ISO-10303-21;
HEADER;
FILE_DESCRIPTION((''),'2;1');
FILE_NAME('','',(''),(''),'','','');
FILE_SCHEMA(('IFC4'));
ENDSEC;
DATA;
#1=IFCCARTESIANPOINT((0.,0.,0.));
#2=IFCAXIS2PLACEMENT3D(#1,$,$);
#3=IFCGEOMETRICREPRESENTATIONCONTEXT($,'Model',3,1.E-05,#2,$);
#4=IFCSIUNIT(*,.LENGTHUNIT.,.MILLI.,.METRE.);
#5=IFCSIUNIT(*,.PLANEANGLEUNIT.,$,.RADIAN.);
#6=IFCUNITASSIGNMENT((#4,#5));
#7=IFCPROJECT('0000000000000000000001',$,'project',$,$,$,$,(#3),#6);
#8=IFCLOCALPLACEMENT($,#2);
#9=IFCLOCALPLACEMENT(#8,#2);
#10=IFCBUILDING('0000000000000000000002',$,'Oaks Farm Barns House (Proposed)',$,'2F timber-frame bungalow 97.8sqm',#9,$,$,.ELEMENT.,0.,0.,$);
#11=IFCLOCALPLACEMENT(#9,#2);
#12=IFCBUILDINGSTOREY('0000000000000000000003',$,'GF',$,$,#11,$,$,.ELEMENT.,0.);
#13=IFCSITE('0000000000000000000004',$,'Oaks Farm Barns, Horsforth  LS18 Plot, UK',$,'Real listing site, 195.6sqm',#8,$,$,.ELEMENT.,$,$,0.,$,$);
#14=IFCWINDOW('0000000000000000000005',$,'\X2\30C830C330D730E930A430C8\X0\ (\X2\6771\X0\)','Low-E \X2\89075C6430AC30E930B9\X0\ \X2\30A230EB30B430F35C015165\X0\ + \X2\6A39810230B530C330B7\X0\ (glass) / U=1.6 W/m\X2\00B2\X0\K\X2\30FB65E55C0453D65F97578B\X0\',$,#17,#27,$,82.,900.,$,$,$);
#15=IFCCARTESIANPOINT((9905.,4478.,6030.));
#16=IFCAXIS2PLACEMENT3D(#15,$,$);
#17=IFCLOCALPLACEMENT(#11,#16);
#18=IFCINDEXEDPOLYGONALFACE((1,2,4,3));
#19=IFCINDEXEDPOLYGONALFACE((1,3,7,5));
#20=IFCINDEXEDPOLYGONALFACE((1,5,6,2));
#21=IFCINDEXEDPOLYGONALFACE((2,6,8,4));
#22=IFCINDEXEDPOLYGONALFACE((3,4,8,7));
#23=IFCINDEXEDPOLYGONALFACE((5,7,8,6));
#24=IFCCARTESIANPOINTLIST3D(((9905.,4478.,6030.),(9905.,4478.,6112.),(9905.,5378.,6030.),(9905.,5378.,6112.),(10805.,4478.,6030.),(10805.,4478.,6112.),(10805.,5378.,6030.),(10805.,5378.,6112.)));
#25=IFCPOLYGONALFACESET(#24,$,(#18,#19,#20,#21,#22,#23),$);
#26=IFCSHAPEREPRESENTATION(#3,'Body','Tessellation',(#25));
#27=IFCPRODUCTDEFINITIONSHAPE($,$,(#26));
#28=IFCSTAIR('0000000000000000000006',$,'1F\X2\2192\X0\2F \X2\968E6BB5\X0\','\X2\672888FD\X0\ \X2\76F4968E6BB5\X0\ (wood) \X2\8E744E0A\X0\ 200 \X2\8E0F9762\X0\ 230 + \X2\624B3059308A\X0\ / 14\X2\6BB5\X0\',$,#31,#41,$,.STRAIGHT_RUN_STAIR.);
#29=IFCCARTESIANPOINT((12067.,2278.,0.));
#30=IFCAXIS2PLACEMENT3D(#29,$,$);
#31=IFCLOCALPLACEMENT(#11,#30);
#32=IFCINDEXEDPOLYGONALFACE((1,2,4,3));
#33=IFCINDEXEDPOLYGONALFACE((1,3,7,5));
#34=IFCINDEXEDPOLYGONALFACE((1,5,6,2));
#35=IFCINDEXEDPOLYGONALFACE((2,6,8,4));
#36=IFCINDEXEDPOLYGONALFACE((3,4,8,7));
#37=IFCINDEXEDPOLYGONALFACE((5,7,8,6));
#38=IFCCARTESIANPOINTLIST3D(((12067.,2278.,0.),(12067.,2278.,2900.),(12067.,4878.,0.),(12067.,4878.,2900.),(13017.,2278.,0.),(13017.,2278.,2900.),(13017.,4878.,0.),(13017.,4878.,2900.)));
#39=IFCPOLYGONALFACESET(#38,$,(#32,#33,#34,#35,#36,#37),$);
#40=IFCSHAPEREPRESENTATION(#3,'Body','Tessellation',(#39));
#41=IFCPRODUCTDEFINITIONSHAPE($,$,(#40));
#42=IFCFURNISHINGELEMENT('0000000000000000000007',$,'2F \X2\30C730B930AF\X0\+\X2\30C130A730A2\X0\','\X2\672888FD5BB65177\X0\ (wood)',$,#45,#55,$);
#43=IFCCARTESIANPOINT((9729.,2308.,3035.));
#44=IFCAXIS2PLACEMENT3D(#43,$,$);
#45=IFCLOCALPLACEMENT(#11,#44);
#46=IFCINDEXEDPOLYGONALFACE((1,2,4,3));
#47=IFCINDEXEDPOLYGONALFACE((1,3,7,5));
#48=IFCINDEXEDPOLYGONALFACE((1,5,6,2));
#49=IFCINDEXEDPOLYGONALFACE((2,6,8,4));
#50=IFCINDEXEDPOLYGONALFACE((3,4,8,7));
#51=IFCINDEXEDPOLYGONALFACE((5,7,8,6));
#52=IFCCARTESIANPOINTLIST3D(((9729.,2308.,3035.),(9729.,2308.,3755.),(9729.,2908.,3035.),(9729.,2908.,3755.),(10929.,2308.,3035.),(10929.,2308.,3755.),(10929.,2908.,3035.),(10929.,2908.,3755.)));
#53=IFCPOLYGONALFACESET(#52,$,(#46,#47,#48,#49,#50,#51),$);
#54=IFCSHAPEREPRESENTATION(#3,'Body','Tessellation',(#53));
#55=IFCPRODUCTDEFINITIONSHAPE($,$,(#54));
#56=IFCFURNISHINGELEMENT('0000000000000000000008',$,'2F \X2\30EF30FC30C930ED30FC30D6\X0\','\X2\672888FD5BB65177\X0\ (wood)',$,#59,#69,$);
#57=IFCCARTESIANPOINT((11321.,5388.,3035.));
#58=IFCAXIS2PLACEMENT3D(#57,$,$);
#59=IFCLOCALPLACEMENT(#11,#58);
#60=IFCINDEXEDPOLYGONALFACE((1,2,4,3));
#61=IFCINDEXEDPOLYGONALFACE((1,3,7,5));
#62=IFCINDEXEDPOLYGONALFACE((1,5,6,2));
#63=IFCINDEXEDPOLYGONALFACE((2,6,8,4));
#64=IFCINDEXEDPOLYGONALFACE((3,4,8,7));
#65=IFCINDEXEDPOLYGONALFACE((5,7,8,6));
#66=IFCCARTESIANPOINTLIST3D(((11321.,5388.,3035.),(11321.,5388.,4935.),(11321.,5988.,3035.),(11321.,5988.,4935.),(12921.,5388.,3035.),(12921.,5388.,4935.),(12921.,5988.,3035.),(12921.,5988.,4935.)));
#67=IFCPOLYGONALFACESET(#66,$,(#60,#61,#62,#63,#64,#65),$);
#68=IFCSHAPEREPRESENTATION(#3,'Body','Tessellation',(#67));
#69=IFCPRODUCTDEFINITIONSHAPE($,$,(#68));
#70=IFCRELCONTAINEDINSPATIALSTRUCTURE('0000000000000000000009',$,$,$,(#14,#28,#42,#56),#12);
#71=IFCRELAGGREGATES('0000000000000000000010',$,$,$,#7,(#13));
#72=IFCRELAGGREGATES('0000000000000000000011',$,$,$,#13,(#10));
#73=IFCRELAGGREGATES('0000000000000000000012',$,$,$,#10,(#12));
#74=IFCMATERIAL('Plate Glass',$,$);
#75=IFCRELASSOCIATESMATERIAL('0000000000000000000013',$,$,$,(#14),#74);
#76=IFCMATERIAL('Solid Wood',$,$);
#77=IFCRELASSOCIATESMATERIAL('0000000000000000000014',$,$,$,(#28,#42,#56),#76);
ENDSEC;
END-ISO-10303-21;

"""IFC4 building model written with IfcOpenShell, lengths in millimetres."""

from ifc_helpers import new_model, si_unit, frame, frame_2d, origin, place, context, project, spatial, rectangle, extrude, material, element, save


model = new_model("IFC4")

# Units and contexts
model_context = context("Model", 3, precision=1e-05, world=origin())
ifc_project = project(units=[si_unit("LENGTHUNIT", "METRE", prefix="MILLI"), si_unit("PLANEANGLEUNIT", "RADIAN")], contexts=[model_context])

# Site, building, storey
site_placement = place(None, origin())
site = spatial("IfcSite", under=ifc_project, at=site_placement, Name="Oaks Farm Barns, Horsforth  LS18 Plot, UK", ObjectType="Real listing site, 195.6sqm", CompositionType="ELEMENT", RefElevation=0.0)
building_placement = place(site_placement, origin())
building = spatial("IfcBuilding", under=site, at=building_placement, Name="Oaks Farm Barns House (Proposed)", ObjectType="2F timber-frame bungalow 97.8sqm", CompositionType="ELEMENT", ElevationOfRefHeight=0.0, ElevationOfTerrain=0.0)
storey_placement = place(building_placement, origin())
storey = spatial("IfcBuildingStorey", under=building, at=storey_placement, Name="GF", CompositionType="ELEMENT", Elevation=0.0)

# Shared definitions
ifc_material_1 = material(Name="Solid Wood")

# Shared definitions
ifc_material_2 = material(Name="Plate Glass")

# Window
window_1_placement = place(storey_placement, frame((9905.0, 4478.0, 6030.0)))
element("IfcWindow", 1, at=window_1_placement, inside=storey, material=ifc_material_2, Name="トップライト (東)", Description="Low-E 複層ガラス アルゴン封入 + 樹脂サッシ (glass) / U=1.6 W/m²K・日射取得型", OverallHeight=82.0, OverallWidth=900.0, context=model_context, shape_type="SweptSolid", body=[
    extrude(rectangle(XDim=900.0, YDim=900.0, at=frame_2d((450.0, 450.0))), frame((9905.0, 4478.0, 6030.0)), (0.0, 0.0, 1.0), 82.0),
])

# Stair
stair_placement = place(storey_placement, frame((12067.0, 2278.0, 0.0)))
element("IfcStair", 2, at=stair_placement, inside=storey, material=ifc_material_1, Name="1F→2F 階段", Description="木製 直階段 (wood) 蹴上 200 踏面 230 + 手すり / 14段", PredefinedType="STRAIGHT_RUN_STAIR", context=model_context, shape_type="SweptSolid", body=[
    extrude(rectangle(XDim=950.0, YDim=2600.0, at=frame_2d((475.0, 1300.0))), frame((12067.0, 2278.0, 0.0)), (0.0, 0.0, 1.0), 2900.0),
])

# Furnishing elements
furnishing_1_placement = place(storey_placement, frame((9729.0, 2308.0, 3035.0)))
element("IfcFurnishingElement", 3, at=furnishing_1_placement, inside=storey, material=ifc_material_1, Name="2F デスク+チェア", Description="木製家具 (wood)", context=model_context, shape_type="SweptSolid", body=[
    extrude(rectangle(XDim=1200.0, YDim=600.0, at=frame_2d((600.0, 300.0))), frame((9729.0, 2308.0, 3035.0)), (0.0, 0.0, 1.0), 720.0),
])
furnishing_2_placement = place(storey_placement, frame((11321.0, 5388.0, 3035.0)))
element("IfcFurnishingElement", 4, at=furnishing_2_placement, inside=storey, material=ifc_material_1, Name="2F ワードローブ", Description="木製家具 (wood)", context=model_context, shape_type="SweptSolid", body=[
    extrude(rectangle(XDim=1600.0, YDim=600.0, at=frame_2d((800.0, 300.0))), frame((11321.0, 5388.0, 3035.0)), (0.0, 0.0, 1.0), 1900.0),
])

save(model, "model.ifc")
